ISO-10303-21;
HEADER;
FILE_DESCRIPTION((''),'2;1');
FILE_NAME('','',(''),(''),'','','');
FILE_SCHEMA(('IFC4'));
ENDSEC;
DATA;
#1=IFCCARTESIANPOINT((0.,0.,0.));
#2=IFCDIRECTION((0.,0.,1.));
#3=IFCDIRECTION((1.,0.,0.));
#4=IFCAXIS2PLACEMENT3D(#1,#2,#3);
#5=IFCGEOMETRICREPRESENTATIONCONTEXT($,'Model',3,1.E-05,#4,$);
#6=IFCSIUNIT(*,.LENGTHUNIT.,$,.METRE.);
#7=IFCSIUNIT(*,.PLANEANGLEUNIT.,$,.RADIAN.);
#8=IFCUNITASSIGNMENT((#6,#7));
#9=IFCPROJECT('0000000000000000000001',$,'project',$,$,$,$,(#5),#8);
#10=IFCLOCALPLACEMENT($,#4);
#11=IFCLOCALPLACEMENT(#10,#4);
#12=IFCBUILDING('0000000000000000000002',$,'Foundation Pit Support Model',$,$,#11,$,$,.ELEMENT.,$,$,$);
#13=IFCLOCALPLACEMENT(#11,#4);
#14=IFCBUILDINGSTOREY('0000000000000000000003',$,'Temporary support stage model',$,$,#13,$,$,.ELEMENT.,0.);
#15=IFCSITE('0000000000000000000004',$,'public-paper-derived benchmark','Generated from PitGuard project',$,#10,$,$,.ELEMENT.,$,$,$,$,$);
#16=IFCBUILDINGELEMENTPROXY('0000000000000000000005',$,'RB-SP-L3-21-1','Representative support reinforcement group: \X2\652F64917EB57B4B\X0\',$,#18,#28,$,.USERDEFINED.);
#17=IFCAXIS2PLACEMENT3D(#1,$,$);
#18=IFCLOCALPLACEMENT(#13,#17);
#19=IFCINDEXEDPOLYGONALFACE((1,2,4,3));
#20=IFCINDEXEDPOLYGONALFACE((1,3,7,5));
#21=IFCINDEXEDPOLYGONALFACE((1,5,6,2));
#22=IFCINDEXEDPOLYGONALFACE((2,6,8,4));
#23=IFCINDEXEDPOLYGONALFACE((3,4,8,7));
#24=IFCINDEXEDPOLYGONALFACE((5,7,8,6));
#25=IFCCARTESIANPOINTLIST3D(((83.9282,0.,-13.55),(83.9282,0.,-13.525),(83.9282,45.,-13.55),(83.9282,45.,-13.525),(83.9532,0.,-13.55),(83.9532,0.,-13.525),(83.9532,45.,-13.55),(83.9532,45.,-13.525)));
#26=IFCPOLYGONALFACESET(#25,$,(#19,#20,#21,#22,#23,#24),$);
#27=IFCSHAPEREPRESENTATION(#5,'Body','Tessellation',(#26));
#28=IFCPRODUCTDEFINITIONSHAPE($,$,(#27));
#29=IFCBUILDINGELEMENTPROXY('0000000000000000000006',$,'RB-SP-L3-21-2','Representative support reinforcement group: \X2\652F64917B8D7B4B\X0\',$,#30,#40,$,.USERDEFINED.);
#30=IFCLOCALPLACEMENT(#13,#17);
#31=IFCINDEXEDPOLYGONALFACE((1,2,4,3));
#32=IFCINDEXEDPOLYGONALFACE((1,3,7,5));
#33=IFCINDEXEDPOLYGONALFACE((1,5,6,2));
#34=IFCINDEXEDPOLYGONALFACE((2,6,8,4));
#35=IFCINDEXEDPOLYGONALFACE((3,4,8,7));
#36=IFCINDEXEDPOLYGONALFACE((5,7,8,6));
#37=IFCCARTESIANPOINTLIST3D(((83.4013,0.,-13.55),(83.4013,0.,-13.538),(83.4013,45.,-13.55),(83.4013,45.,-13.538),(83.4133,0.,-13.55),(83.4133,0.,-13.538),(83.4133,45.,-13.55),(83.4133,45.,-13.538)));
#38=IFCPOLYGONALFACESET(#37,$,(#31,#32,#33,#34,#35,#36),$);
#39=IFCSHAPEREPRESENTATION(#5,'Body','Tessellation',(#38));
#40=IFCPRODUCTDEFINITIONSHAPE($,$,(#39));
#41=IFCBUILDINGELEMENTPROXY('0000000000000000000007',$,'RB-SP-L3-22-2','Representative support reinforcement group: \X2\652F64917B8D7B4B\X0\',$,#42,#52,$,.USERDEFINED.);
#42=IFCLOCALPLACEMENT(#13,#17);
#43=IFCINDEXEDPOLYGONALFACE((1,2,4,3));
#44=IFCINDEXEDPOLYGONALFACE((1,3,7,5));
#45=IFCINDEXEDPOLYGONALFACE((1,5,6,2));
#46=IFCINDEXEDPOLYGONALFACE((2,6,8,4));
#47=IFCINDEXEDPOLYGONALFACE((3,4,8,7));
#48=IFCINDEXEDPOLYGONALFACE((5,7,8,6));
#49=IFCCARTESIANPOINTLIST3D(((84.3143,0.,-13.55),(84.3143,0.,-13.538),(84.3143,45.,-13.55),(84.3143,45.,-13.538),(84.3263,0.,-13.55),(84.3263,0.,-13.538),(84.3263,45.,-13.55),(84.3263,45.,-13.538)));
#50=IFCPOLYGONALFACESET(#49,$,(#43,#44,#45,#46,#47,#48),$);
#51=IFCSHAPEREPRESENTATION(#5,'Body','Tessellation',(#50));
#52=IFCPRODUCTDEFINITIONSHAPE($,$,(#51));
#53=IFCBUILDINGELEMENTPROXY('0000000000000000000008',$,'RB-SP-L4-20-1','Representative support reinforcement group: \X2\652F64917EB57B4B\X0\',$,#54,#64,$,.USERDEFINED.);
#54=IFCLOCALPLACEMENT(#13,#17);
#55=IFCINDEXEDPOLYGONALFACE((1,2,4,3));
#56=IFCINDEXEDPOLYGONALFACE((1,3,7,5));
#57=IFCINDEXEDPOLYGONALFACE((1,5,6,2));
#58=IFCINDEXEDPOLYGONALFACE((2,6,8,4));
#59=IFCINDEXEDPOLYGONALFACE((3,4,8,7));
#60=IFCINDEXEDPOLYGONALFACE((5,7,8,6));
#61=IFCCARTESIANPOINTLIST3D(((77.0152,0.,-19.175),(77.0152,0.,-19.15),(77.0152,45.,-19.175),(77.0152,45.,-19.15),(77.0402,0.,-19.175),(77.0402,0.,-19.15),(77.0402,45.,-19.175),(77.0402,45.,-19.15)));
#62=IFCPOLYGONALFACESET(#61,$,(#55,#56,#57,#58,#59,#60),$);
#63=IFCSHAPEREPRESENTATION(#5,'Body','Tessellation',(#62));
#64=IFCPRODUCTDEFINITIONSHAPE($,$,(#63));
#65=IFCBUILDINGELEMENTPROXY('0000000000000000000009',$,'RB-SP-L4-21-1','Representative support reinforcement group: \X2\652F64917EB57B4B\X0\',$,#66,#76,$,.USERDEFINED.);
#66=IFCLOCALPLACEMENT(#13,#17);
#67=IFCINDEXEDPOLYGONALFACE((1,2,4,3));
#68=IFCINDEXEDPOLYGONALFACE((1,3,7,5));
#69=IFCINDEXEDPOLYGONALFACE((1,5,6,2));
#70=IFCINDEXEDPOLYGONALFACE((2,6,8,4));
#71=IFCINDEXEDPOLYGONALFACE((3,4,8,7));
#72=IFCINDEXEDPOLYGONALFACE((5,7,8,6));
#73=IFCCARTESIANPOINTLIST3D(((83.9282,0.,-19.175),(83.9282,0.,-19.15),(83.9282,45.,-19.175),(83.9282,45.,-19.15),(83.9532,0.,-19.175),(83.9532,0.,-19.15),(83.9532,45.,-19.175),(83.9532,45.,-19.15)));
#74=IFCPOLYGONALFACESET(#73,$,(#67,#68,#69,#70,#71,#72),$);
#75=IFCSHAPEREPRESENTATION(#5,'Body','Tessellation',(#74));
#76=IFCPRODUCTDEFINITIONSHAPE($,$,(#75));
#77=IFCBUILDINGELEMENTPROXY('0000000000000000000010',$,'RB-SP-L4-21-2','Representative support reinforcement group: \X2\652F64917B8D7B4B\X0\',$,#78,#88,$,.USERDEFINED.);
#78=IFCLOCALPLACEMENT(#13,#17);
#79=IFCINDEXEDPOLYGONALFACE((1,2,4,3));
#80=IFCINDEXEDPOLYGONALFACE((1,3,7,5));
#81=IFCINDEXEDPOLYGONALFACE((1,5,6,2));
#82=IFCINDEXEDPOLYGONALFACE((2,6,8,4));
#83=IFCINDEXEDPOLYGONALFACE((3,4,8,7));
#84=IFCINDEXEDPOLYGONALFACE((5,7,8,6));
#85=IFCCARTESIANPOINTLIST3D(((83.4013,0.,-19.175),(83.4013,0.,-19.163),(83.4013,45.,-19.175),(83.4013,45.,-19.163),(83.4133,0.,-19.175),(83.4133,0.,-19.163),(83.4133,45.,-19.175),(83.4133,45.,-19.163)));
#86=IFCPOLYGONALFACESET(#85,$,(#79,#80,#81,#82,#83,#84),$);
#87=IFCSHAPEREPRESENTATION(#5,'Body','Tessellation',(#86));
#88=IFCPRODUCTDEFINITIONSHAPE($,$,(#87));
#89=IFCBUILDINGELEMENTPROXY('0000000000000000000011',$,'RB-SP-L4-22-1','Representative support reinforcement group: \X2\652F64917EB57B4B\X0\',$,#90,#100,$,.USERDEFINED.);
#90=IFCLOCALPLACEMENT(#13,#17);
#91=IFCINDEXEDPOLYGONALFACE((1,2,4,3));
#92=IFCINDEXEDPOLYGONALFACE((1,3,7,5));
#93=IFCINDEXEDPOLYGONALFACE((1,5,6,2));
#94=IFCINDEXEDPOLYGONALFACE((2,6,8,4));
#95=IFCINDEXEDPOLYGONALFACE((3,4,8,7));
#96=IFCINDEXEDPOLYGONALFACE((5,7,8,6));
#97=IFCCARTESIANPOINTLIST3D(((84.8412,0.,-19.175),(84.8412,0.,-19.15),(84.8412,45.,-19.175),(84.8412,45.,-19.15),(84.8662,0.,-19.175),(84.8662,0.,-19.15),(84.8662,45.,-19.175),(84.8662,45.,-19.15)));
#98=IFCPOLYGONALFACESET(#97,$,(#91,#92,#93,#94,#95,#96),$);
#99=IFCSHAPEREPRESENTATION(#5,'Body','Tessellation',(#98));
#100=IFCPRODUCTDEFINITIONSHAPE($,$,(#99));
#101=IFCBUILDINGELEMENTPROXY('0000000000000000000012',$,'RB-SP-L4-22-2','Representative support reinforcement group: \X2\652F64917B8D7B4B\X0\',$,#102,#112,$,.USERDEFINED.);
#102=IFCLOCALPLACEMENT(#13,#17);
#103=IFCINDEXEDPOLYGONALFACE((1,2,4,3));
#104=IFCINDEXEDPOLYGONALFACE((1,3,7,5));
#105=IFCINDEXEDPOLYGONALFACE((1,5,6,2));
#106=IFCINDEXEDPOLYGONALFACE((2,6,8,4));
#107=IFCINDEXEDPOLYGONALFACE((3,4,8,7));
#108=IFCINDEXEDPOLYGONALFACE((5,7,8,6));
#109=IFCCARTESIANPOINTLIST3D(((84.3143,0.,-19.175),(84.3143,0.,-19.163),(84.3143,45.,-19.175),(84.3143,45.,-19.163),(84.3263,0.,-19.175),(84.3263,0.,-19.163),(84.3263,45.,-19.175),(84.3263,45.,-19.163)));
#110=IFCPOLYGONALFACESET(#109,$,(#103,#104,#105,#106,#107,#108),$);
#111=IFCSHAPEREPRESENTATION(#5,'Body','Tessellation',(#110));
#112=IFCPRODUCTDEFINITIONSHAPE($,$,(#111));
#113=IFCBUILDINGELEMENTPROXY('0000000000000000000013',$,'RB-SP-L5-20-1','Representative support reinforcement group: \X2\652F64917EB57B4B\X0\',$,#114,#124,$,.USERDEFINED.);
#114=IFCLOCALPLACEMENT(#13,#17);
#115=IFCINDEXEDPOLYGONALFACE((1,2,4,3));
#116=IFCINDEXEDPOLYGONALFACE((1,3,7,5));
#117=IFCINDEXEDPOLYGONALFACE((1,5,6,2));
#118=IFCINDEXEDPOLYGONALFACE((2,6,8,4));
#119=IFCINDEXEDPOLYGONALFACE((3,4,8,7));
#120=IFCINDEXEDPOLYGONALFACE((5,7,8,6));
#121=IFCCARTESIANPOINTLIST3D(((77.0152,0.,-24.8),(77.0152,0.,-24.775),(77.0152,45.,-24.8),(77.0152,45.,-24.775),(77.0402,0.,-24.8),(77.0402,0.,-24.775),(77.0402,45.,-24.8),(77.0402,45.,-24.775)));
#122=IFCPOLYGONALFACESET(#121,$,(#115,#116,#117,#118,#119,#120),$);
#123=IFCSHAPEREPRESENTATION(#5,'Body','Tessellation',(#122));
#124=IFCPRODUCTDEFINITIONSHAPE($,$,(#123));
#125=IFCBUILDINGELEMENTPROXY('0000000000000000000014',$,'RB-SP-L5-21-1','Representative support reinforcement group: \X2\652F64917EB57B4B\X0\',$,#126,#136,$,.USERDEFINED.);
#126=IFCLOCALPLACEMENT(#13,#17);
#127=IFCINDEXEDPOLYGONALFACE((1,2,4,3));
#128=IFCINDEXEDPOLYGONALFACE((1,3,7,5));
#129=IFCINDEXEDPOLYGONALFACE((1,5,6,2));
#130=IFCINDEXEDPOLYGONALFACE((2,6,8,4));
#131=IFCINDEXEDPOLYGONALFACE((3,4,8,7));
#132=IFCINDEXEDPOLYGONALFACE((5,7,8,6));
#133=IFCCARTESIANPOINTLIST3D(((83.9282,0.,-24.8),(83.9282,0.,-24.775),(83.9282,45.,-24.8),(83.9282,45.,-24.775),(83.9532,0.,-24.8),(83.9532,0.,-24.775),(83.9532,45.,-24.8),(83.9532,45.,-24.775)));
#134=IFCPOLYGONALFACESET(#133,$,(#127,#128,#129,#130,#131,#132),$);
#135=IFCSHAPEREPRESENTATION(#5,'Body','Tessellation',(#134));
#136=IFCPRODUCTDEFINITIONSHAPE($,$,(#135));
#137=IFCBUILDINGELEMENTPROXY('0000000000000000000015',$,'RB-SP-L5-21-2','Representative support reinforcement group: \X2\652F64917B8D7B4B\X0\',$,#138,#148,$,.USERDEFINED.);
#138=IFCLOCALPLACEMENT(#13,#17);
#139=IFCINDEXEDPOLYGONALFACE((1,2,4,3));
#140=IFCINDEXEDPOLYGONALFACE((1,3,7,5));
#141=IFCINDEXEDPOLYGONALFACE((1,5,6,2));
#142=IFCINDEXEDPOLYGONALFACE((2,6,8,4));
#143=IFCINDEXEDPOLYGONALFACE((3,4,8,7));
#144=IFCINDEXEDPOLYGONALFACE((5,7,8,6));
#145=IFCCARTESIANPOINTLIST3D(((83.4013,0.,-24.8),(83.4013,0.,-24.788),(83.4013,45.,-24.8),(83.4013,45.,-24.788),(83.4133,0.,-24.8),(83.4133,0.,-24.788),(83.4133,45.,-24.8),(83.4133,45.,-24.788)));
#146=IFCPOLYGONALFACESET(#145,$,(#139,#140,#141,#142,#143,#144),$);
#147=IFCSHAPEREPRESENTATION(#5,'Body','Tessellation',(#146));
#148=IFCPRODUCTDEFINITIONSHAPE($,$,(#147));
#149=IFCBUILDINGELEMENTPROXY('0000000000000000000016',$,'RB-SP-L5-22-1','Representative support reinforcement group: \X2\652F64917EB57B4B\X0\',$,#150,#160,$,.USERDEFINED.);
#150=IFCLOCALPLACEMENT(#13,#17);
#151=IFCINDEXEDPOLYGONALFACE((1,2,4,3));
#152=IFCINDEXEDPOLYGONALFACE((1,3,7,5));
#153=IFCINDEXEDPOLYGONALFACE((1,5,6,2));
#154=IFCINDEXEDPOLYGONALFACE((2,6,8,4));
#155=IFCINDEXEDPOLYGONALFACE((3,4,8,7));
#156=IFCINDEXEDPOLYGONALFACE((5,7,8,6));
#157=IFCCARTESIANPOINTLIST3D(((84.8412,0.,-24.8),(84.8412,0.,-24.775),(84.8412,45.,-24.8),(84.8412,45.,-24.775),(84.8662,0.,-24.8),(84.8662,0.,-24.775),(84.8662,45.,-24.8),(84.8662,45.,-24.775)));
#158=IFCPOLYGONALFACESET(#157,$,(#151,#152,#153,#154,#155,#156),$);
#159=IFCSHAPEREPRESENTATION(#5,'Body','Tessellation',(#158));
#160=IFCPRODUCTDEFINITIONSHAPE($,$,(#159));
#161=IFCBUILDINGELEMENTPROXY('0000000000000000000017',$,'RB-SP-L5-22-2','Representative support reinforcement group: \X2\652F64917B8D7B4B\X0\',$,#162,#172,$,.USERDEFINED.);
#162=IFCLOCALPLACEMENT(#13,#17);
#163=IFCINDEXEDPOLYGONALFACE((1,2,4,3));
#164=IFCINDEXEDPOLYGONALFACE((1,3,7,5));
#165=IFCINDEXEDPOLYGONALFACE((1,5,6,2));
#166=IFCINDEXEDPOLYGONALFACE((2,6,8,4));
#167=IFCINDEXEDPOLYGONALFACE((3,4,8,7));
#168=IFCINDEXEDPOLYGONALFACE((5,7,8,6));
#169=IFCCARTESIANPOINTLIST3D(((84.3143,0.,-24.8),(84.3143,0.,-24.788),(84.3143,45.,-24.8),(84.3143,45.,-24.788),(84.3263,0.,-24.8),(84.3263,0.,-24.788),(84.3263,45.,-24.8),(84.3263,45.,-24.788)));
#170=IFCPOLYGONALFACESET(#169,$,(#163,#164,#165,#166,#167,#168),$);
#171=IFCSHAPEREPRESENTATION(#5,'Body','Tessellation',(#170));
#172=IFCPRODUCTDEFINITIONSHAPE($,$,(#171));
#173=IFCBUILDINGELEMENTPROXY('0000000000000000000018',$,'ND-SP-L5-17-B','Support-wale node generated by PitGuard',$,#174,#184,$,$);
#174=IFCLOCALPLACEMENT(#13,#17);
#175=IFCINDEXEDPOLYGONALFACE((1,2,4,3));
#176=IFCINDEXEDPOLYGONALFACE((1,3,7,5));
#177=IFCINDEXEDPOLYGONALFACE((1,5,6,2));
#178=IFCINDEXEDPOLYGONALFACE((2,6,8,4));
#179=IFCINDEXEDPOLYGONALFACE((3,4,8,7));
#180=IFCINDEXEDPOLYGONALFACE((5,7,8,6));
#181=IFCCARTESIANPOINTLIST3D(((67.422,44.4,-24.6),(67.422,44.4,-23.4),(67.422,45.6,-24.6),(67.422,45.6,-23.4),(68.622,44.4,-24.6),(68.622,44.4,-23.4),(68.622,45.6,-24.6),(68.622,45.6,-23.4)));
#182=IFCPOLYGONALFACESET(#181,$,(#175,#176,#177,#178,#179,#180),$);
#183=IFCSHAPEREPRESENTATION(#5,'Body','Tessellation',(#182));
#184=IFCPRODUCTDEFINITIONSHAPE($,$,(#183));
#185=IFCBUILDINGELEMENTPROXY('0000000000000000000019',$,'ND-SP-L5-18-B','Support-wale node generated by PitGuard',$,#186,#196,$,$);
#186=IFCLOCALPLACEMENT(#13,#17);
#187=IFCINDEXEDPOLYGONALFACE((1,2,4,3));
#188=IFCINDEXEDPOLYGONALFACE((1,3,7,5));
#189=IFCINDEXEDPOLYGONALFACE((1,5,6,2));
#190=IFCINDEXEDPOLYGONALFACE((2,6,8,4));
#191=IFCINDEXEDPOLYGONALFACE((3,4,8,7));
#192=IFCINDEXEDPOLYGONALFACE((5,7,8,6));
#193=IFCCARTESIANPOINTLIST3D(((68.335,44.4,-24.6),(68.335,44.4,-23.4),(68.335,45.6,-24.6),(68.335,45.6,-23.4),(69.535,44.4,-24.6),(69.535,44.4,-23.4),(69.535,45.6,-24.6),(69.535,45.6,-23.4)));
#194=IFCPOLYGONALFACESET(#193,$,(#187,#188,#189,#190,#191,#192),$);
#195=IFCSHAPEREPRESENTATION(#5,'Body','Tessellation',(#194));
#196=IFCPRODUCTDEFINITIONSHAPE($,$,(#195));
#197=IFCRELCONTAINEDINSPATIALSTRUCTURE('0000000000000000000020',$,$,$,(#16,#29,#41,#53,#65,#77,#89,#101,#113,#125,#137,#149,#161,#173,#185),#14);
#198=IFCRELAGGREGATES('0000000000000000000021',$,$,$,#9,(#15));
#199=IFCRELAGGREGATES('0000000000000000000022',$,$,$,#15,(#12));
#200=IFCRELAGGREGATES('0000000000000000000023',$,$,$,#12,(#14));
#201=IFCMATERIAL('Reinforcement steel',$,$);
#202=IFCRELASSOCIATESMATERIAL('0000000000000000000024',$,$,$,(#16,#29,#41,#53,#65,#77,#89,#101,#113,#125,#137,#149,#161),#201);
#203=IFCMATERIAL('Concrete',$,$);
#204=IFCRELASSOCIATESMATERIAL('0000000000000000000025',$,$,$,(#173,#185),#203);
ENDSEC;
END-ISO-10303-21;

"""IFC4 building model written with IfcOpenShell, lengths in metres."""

from ifc_helpers import new_model, si_unit, frame, origin_with_axes, origin_2d, place, context, project, spatial, rectangle, extrude, material, element, save


model = new_model("IFC4")

# Units and contexts
model_context = context("Model", 3, precision=1e-05, world=origin_with_axes())
ifc_project = project(units=[si_unit("LENGTHUNIT", "METRE"), si_unit("PLANEANGLEUNIT", "RADIAN")], contexts=[model_context])

# Site, building, storey
site_placement = place(None, origin_with_axes())
site = spatial("IfcSite", under=ifc_project, at=site_placement, Name="public-paper-derived benchmark", Description="Generated from PitGuard project", CompositionType="ELEMENT")
building_placement = place(site_placement, origin_with_axes())
building = spatial("IfcBuilding", under=site, at=building_placement, Name="Foundation Pit Support Model", CompositionType="ELEMENT")
storey_placement = place(building_placement, origin_with_axes())
storey = spatial("IfcBuildingStorey", under=building, at=storey_placement, Name="Temporary support stage model", CompositionType="ELEMENT", Elevation=0.0)

# Shared definitions
ifc_material_1 = material(Name="Concrete")

# Building element proxies
ifc_material_2 = material(Name="Reinforcement steel")
for number, where, z_axis, x_axis, name in (
    (1, (83.9407, 22.5, -13.55), (0.0, 0.0, 1.0), (0.0, 1.0, 0.0), "RB-SP-L3-21-1"),
):
    element("IfcBuildingElementProxy", number, at=place(storey_placement, frame(where, z_axis=z_axis, x_axis=x_axis)), inside=storey, material=ifc_material_2, Name=name, Description="Representative support reinforcement group: 支撑纵筋", PredefinedType="USERDEFINED", context=model_context, shape_type="SweptSolid", body=[
        extrude(rectangle(XDim=45.0, YDim=0.025, at=origin_2d()), origin_with_axes(), (0.0, 0.0, 1.0), 0.025),
    ])
for number, where, z_axis, x_axis, name in (
    (2, (83.4073, 22.5, -13.55), (0.0, 0.0, 1.0), (0.0, 1.0, 0.0), "RB-SP-L3-21-2"),
    (3, (84.3203, 22.5, -13.55), (0.0, 0.0, 1.0), (0.0, 1.0, 0.0), "RB-SP-L3-22-2"),
):
    element("IfcBuildingElementProxy", number, at=place(storey_placement, frame(where, z_axis=z_axis, x_axis=x_axis)), inside=storey, material=ifc_material_2, Name=name, Description="Representative support reinforcement group: 支撑箍筋", PredefinedType="USERDEFINED", context=model_context, shape_type="SweptSolid", body=[
        extrude(rectangle(XDim=45.0, YDim=0.012, at=origin_2d()), origin_with_axes(), (0.0, 0.0, 1.0), 0.012),
    ])
for number, where, z_axis, x_axis, name in (
    (4, (77.0277, 22.5, -19.175), (0.0, 0.0, 1.0), (0.0, 1.0, 0.0), "RB-SP-L4-20-1"),
    (5, (83.9407, 22.5, -19.175), (0.0, 0.0, 1.0), (0.0, 1.0, 0.0), "RB-SP-L4-21-1"),
):
    element("IfcBuildingElementProxy", number, at=place(storey_placement, frame(where, z_axis=z_axis, x_axis=x_axis)), inside=storey, material=ifc_material_2, Name=name, Description="Representative support reinforcement group: 支撑纵筋", PredefinedType="USERDEFINED", context=model_context, shape_type="SweptSolid", body=[
        extrude(rectangle(XDim=45.0, YDim=0.025, at=origin_2d()), origin_with_axes(), (0.0, 0.0, 1.0), 0.025),
    ])
proxy_1_placement = place(storey_placement, frame((83.4073, 22.5, -19.175), z_axis=(0.0, 0.0, 1.0), x_axis=(0.0, 1.0, 0.0)))
element("IfcBuildingElementProxy", 6, at=proxy_1_placement, inside=storey, material=ifc_material_2, Name="RB-SP-L4-21-2", Description="Representative support reinforcement group: 支撑箍筋", PredefinedType="USERDEFINED", context=model_context, shape_type="SweptSolid", body=[
    extrude(rectangle(XDim=45.0, YDim=0.012, at=origin_2d()), origin_with_axes(), (0.0, 0.0, 1.0), 0.012),
])
proxy_2_placement = place(storey_placement, frame((84.8537, 22.5, -19.175), z_axis=(0.0, 0.0, 1.0), x_axis=(0.0, 1.0, 0.0)))
element("IfcBuildingElementProxy", 7, at=proxy_2_placement, inside=storey, material=ifc_material_2, Name="RB-SP-L4-22-1", Description="Representative support reinforcement group: 支撑纵筋", PredefinedType="USERDEFINED", context=model_context, shape_type="SweptSolid", body=[
    extrude(rectangle(XDim=45.0, YDim=0.025, at=origin_2d()), origin_with_axes(), (0.0, 0.0, 1.0), 0.025),
])
proxy_3_placement = place(storey_placement, frame((84.3203, 22.5, -19.175), z_axis=(0.0, 0.0, 1.0), x_axis=(0.0, 1.0, 0.0)))
element("IfcBuildingElementProxy", 8, at=proxy_3_placement, inside=storey, material=ifc_material_2, Name="RB-SP-L4-22-2", Description="Representative support reinforcement group: 支撑箍筋", PredefinedType="USERDEFINED", context=model_context, shape_type="SweptSolid", body=[
    extrude(rectangle(XDim=45.0, YDim=0.012, at=origin_2d()), origin_with_axes(), (0.0, 0.0, 1.0), 0.012),
])
for number, where, z_axis, x_axis, name in (
    (9, (77.0277, 22.5, -24.8), (0.0, 0.0, 1.0), (0.0, 1.0, 0.0), "RB-SP-L5-20-1"),
    (10, (83.9407, 22.5, -24.8), (0.0, 0.0, 1.0), (0.0, 1.0, 0.0), "RB-SP-L5-21-1"),
):
    element("IfcBuildingElementProxy", number, at=place(storey_placement, frame(where, z_axis=z_axis, x_axis=x_axis)), inside=storey, material=ifc_material_2, Name=name, Description="Representative support reinforcement group: 支撑纵筋", PredefinedType="USERDEFINED", context=model_context, shape_type="SweptSolid", body=[
        extrude(rectangle(XDim=45.0, YDim=0.025, at=origin_2d()), origin_with_axes(), (0.0, 0.0, 1.0), 0.025),
    ])
proxy_4_placement = place(storey_placement, frame((83.4073, 22.5, -24.8), z_axis=(0.0, 0.0, 1.0), x_axis=(0.0, 1.0, 0.0)))
element("IfcBuildingElementProxy", 11, at=proxy_4_placement, inside=storey, material=ifc_material_2, Name="RB-SP-L5-21-2", Description="Representative support reinforcement group: 支撑箍筋", PredefinedType="USERDEFINED", context=model_context, shape_type="SweptSolid", body=[
    extrude(rectangle(XDim=45.0, YDim=0.012, at=origin_2d()), origin_with_axes(), (0.0, 0.0, 1.0), 0.012),
])
proxy_5_placement = place(storey_placement, frame((84.8537, 22.5, -24.8), z_axis=(0.0, 0.0, 1.0), x_axis=(0.0, 1.0, 0.0)))
element("IfcBuildingElementProxy", 12, at=proxy_5_placement, inside=storey, material=ifc_material_2, Name="RB-SP-L5-22-1", Description="Representative support reinforcement group: 支撑纵筋", PredefinedType="USERDEFINED", context=model_context, shape_type="SweptSolid", body=[
    extrude(rectangle(XDim=45.0, YDim=0.025, at=origin_2d()), origin_with_axes(), (0.0, 0.0, 1.0), 0.025),
])
proxy_6_placement = place(storey_placement, frame((84.3203, 22.5, -24.8), z_axis=(0.0, 0.0, 1.0), x_axis=(0.0, 1.0, 0.0)))
element("IfcBuildingElementProxy", 13, at=proxy_6_placement, inside=storey, material=ifc_material_2, Name="RB-SP-L5-22-2", Description="Representative support reinforcement group: 支撑箍筋", PredefinedType="USERDEFINED", context=model_context, shape_type="SweptSolid", body=[
    extrude(rectangle(XDim=45.0, YDim=0.012, at=origin_2d()), origin_with_axes(), (0.0, 0.0, 1.0), 0.012),
])
for number, where, z_axis, x_axis, name in (
    (14, (68.022, 45.0, -24.6), (0.0, 0.0, 1.0), (1.0, 0.0, 0.0), "ND-SP-L5-17-B"),
    (15, (68.935, 45.0, -24.6), (0.0, 0.0, 1.0), (1.0, 0.0, 0.0), "ND-SP-L5-18-B"),
):
    element("IfcBuildingElementProxy", number, at=place(storey_placement, frame(where, z_axis=z_axis, x_axis=x_axis)), inside=storey, material=ifc_material_1, Name=name, Description="Support-wale node generated by PitGuard", context=model_context, shape_type="SweptSolid", body=[
        extrude(rectangle(XDim=1.2, YDim=1.2, at=origin_2d()), origin_with_axes(), (0.0, 0.0, 1.0), 1.2),
    ])

save(model, "model.ifc")
